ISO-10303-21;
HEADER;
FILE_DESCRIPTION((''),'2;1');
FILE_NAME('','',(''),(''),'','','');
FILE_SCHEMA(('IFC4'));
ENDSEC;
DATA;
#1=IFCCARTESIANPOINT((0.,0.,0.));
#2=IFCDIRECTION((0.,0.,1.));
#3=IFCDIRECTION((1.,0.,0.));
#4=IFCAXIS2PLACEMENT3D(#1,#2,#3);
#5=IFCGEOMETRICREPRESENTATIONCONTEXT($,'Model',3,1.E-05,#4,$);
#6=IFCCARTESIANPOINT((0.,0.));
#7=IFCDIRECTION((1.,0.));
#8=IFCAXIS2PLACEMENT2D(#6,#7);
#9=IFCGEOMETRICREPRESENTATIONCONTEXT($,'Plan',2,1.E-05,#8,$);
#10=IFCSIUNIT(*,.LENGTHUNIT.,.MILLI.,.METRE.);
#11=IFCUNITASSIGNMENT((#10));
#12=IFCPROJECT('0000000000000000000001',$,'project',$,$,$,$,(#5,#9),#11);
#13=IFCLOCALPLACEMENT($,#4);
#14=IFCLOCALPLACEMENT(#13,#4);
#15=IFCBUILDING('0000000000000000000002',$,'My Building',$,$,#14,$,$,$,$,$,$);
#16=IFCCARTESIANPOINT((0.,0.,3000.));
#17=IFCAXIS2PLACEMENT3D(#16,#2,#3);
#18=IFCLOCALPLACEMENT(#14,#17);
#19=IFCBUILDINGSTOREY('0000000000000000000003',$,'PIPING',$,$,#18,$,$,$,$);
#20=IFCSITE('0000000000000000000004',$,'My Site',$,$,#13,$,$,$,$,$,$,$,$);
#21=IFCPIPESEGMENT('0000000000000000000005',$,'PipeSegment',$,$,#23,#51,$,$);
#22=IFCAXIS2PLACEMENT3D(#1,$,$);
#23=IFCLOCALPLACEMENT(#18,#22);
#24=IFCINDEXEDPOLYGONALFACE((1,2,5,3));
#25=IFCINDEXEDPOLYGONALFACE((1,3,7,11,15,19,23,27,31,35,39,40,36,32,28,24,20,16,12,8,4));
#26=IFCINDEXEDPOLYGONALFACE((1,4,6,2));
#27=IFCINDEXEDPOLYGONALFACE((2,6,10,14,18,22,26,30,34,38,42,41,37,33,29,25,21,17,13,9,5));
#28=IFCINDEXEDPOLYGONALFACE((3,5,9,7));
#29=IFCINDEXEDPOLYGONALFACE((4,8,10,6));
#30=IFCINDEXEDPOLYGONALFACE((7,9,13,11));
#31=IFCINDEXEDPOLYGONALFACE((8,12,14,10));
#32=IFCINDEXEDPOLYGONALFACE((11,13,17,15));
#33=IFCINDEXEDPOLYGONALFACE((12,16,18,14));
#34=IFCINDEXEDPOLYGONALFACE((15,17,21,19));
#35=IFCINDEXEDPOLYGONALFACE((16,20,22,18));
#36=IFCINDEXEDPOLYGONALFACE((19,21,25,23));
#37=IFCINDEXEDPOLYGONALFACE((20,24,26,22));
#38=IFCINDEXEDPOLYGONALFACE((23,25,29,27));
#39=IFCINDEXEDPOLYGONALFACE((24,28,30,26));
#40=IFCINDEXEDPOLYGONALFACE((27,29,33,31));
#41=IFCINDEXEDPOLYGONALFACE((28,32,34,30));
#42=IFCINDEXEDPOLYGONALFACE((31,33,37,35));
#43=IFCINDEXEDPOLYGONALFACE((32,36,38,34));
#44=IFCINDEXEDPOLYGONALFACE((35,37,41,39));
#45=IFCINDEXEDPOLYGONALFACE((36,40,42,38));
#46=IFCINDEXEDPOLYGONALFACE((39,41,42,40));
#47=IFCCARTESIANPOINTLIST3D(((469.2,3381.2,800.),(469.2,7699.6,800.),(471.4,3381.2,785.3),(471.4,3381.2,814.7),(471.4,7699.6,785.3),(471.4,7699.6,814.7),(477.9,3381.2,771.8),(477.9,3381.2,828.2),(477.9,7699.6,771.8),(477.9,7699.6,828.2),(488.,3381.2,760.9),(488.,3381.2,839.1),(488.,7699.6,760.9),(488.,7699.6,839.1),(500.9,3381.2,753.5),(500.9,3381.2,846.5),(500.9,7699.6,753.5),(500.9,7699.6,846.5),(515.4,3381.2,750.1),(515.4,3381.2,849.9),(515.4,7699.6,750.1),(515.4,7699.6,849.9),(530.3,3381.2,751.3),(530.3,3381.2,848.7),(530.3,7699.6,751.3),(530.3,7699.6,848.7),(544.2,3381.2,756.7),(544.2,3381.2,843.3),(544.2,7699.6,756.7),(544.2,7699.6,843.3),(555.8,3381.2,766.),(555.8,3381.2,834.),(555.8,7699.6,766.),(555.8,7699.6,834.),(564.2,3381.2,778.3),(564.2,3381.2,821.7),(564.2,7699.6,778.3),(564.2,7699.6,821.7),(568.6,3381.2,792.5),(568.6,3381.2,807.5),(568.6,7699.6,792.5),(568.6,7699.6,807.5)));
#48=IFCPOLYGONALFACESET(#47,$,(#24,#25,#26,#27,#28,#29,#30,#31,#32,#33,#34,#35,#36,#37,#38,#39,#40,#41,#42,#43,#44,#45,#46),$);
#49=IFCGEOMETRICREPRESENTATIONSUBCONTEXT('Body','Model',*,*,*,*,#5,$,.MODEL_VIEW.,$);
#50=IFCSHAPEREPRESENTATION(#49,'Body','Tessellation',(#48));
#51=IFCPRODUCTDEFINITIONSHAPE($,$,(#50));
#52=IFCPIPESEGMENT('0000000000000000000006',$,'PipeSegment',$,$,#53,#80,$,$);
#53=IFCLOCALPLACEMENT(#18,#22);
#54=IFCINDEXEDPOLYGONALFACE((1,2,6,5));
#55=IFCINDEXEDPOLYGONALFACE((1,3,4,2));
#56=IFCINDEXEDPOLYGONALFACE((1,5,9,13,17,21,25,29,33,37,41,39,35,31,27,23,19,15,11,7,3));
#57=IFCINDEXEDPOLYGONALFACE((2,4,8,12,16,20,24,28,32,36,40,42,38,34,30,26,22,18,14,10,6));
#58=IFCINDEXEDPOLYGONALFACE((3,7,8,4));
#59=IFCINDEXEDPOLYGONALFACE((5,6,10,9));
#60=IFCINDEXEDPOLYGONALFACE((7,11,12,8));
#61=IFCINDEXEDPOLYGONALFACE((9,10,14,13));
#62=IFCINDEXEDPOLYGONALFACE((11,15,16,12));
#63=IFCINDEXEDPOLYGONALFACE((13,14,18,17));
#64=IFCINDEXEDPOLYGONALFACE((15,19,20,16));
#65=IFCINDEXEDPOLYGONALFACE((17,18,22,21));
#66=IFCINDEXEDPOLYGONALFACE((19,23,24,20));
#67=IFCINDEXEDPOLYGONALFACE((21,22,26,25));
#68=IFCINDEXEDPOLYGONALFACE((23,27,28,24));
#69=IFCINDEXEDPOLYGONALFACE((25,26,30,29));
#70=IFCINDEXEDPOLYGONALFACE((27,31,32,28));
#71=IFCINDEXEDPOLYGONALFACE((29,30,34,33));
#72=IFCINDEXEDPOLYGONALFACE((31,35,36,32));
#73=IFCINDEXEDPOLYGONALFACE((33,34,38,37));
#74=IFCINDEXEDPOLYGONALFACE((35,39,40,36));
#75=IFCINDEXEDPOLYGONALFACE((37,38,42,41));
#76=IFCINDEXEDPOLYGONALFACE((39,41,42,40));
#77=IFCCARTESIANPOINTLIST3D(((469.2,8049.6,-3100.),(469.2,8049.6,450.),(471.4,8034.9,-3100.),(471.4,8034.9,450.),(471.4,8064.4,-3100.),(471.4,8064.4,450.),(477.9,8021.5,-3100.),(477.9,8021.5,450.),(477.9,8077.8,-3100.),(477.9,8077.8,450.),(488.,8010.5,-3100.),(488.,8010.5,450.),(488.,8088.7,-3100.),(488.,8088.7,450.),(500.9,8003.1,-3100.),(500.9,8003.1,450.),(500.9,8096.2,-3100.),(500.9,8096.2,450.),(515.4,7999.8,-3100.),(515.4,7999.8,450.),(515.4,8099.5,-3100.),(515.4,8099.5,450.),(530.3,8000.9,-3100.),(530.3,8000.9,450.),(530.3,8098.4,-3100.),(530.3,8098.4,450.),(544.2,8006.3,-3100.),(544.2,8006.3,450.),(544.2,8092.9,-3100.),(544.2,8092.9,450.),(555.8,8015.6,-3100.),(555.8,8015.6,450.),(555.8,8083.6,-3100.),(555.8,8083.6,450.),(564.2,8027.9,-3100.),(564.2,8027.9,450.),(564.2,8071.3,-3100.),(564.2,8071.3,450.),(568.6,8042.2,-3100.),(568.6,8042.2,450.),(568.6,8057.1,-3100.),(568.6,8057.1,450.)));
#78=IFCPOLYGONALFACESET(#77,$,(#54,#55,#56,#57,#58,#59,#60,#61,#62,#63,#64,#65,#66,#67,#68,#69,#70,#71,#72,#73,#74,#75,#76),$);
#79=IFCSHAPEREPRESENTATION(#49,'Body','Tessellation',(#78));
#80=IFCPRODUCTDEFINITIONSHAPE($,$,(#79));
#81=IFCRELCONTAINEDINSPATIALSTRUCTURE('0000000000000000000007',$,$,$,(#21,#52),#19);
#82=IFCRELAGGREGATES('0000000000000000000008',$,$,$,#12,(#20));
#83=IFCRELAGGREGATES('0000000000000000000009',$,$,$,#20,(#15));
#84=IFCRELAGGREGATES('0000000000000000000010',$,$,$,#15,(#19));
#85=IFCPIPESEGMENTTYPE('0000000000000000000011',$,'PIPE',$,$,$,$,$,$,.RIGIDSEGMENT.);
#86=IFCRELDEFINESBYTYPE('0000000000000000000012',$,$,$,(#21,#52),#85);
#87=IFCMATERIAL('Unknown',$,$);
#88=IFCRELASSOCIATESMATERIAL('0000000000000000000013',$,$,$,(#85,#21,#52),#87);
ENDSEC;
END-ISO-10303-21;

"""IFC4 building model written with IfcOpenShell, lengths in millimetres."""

from ifc_helpers import new_model, si_unit, frame, origin_with_axes, origin_2d_with_axis, place, context, subcontext, project, spatial, circle, extrude, material, material_profile, profile_set, profile_usage, type_object, element, save


model = new_model("IFC4")

# Units and contexts
model_context = context("Model", 3, precision=1e-05, world=origin_with_axes())
plan_context = context("Plan", 2, precision=1e-05, world=origin_2d_with_axis())
body_context = subcontext(model_context, "Body", "Model", "MODEL_VIEW")
ifc_project = project(units=[si_unit("LENGTHUNIT", "METRE", prefix="MILLI")], contexts=[model_context, plan_context])

# Site, building, storey
site_placement = place(None, origin_with_axes())
site = spatial("IfcSite", under=ifc_project, at=site_placement, Name="My Site")
building_placement = place(site_placement, origin_with_axes())
building = spatial("IfcBuilding", under=site, at=building_placement, Name="My Building")
storey_placement = place(building_placement, frame((0.0, 0.0, 3000.0), z_axis=(0.0, 0.0, 1.0), x_axis=(1.0, 0.0, 0.0)))
storey = spatial("IfcBuildingStorey", under=building, at=storey_placement, Name="PIPING")

# Pipe segments
ifc_material = material(Name="Unknown")
ifc_material_profile = material_profile(ifc_material, circle(Radius=50.0))
ifc_profile_set = profile_set([ifc_material_profile])
ifc_profile_usage_1 = profile_usage(ifc_profile_set, cardinal=5)
pipe_segment_type = type_object("IfcPipeSegmentType", Name="PIPE", PredefinedType="RIGIDSEGMENT", material=ifc_profile_set)
pipe_segment_1_placement = place(storey_placement, frame((519.2, 3381.2, 800.0), z_axis=(0.0, 1.0, 0.0), x_axis=(-1.0, 0.0, 0.0)))
element("IfcPipeSegment", 1, at=pipe_segment_1_placement, inside=storey, type_object=pipe_segment_type, material=ifc_profile_usage_1, Name="PipeSegment", context=body_context, shape_type="SweptSolid", body=[
    extrude(circle(Radius=50.0), origin_with_axes(), (0.0, 0.0, 1.0), 4318.4),
])
ifc_profile_usage_2 = profile_usage(ifc_profile_set, cardinal=5)
pipe_segment_2_placement = place(storey_placement, frame((519.2, 8049.6, -3100.0), z_axis=(0.0, 0.0, 1.0), x_axis=(-1.0, 0.0, 0.0)))
element("IfcPipeSegment", 2, at=pipe_segment_2_placement, inside=storey, type_object=pipe_segment_type, material=ifc_profile_usage_2, Name="PipeSegment", context=body_context, shape_type="SweptSolid", body=[
    extrude(circle(Radius=50.0), origin_with_axes(), (0.0, 0.0, 1.0), 3550.0),
])

save(model, "model.ifc")
